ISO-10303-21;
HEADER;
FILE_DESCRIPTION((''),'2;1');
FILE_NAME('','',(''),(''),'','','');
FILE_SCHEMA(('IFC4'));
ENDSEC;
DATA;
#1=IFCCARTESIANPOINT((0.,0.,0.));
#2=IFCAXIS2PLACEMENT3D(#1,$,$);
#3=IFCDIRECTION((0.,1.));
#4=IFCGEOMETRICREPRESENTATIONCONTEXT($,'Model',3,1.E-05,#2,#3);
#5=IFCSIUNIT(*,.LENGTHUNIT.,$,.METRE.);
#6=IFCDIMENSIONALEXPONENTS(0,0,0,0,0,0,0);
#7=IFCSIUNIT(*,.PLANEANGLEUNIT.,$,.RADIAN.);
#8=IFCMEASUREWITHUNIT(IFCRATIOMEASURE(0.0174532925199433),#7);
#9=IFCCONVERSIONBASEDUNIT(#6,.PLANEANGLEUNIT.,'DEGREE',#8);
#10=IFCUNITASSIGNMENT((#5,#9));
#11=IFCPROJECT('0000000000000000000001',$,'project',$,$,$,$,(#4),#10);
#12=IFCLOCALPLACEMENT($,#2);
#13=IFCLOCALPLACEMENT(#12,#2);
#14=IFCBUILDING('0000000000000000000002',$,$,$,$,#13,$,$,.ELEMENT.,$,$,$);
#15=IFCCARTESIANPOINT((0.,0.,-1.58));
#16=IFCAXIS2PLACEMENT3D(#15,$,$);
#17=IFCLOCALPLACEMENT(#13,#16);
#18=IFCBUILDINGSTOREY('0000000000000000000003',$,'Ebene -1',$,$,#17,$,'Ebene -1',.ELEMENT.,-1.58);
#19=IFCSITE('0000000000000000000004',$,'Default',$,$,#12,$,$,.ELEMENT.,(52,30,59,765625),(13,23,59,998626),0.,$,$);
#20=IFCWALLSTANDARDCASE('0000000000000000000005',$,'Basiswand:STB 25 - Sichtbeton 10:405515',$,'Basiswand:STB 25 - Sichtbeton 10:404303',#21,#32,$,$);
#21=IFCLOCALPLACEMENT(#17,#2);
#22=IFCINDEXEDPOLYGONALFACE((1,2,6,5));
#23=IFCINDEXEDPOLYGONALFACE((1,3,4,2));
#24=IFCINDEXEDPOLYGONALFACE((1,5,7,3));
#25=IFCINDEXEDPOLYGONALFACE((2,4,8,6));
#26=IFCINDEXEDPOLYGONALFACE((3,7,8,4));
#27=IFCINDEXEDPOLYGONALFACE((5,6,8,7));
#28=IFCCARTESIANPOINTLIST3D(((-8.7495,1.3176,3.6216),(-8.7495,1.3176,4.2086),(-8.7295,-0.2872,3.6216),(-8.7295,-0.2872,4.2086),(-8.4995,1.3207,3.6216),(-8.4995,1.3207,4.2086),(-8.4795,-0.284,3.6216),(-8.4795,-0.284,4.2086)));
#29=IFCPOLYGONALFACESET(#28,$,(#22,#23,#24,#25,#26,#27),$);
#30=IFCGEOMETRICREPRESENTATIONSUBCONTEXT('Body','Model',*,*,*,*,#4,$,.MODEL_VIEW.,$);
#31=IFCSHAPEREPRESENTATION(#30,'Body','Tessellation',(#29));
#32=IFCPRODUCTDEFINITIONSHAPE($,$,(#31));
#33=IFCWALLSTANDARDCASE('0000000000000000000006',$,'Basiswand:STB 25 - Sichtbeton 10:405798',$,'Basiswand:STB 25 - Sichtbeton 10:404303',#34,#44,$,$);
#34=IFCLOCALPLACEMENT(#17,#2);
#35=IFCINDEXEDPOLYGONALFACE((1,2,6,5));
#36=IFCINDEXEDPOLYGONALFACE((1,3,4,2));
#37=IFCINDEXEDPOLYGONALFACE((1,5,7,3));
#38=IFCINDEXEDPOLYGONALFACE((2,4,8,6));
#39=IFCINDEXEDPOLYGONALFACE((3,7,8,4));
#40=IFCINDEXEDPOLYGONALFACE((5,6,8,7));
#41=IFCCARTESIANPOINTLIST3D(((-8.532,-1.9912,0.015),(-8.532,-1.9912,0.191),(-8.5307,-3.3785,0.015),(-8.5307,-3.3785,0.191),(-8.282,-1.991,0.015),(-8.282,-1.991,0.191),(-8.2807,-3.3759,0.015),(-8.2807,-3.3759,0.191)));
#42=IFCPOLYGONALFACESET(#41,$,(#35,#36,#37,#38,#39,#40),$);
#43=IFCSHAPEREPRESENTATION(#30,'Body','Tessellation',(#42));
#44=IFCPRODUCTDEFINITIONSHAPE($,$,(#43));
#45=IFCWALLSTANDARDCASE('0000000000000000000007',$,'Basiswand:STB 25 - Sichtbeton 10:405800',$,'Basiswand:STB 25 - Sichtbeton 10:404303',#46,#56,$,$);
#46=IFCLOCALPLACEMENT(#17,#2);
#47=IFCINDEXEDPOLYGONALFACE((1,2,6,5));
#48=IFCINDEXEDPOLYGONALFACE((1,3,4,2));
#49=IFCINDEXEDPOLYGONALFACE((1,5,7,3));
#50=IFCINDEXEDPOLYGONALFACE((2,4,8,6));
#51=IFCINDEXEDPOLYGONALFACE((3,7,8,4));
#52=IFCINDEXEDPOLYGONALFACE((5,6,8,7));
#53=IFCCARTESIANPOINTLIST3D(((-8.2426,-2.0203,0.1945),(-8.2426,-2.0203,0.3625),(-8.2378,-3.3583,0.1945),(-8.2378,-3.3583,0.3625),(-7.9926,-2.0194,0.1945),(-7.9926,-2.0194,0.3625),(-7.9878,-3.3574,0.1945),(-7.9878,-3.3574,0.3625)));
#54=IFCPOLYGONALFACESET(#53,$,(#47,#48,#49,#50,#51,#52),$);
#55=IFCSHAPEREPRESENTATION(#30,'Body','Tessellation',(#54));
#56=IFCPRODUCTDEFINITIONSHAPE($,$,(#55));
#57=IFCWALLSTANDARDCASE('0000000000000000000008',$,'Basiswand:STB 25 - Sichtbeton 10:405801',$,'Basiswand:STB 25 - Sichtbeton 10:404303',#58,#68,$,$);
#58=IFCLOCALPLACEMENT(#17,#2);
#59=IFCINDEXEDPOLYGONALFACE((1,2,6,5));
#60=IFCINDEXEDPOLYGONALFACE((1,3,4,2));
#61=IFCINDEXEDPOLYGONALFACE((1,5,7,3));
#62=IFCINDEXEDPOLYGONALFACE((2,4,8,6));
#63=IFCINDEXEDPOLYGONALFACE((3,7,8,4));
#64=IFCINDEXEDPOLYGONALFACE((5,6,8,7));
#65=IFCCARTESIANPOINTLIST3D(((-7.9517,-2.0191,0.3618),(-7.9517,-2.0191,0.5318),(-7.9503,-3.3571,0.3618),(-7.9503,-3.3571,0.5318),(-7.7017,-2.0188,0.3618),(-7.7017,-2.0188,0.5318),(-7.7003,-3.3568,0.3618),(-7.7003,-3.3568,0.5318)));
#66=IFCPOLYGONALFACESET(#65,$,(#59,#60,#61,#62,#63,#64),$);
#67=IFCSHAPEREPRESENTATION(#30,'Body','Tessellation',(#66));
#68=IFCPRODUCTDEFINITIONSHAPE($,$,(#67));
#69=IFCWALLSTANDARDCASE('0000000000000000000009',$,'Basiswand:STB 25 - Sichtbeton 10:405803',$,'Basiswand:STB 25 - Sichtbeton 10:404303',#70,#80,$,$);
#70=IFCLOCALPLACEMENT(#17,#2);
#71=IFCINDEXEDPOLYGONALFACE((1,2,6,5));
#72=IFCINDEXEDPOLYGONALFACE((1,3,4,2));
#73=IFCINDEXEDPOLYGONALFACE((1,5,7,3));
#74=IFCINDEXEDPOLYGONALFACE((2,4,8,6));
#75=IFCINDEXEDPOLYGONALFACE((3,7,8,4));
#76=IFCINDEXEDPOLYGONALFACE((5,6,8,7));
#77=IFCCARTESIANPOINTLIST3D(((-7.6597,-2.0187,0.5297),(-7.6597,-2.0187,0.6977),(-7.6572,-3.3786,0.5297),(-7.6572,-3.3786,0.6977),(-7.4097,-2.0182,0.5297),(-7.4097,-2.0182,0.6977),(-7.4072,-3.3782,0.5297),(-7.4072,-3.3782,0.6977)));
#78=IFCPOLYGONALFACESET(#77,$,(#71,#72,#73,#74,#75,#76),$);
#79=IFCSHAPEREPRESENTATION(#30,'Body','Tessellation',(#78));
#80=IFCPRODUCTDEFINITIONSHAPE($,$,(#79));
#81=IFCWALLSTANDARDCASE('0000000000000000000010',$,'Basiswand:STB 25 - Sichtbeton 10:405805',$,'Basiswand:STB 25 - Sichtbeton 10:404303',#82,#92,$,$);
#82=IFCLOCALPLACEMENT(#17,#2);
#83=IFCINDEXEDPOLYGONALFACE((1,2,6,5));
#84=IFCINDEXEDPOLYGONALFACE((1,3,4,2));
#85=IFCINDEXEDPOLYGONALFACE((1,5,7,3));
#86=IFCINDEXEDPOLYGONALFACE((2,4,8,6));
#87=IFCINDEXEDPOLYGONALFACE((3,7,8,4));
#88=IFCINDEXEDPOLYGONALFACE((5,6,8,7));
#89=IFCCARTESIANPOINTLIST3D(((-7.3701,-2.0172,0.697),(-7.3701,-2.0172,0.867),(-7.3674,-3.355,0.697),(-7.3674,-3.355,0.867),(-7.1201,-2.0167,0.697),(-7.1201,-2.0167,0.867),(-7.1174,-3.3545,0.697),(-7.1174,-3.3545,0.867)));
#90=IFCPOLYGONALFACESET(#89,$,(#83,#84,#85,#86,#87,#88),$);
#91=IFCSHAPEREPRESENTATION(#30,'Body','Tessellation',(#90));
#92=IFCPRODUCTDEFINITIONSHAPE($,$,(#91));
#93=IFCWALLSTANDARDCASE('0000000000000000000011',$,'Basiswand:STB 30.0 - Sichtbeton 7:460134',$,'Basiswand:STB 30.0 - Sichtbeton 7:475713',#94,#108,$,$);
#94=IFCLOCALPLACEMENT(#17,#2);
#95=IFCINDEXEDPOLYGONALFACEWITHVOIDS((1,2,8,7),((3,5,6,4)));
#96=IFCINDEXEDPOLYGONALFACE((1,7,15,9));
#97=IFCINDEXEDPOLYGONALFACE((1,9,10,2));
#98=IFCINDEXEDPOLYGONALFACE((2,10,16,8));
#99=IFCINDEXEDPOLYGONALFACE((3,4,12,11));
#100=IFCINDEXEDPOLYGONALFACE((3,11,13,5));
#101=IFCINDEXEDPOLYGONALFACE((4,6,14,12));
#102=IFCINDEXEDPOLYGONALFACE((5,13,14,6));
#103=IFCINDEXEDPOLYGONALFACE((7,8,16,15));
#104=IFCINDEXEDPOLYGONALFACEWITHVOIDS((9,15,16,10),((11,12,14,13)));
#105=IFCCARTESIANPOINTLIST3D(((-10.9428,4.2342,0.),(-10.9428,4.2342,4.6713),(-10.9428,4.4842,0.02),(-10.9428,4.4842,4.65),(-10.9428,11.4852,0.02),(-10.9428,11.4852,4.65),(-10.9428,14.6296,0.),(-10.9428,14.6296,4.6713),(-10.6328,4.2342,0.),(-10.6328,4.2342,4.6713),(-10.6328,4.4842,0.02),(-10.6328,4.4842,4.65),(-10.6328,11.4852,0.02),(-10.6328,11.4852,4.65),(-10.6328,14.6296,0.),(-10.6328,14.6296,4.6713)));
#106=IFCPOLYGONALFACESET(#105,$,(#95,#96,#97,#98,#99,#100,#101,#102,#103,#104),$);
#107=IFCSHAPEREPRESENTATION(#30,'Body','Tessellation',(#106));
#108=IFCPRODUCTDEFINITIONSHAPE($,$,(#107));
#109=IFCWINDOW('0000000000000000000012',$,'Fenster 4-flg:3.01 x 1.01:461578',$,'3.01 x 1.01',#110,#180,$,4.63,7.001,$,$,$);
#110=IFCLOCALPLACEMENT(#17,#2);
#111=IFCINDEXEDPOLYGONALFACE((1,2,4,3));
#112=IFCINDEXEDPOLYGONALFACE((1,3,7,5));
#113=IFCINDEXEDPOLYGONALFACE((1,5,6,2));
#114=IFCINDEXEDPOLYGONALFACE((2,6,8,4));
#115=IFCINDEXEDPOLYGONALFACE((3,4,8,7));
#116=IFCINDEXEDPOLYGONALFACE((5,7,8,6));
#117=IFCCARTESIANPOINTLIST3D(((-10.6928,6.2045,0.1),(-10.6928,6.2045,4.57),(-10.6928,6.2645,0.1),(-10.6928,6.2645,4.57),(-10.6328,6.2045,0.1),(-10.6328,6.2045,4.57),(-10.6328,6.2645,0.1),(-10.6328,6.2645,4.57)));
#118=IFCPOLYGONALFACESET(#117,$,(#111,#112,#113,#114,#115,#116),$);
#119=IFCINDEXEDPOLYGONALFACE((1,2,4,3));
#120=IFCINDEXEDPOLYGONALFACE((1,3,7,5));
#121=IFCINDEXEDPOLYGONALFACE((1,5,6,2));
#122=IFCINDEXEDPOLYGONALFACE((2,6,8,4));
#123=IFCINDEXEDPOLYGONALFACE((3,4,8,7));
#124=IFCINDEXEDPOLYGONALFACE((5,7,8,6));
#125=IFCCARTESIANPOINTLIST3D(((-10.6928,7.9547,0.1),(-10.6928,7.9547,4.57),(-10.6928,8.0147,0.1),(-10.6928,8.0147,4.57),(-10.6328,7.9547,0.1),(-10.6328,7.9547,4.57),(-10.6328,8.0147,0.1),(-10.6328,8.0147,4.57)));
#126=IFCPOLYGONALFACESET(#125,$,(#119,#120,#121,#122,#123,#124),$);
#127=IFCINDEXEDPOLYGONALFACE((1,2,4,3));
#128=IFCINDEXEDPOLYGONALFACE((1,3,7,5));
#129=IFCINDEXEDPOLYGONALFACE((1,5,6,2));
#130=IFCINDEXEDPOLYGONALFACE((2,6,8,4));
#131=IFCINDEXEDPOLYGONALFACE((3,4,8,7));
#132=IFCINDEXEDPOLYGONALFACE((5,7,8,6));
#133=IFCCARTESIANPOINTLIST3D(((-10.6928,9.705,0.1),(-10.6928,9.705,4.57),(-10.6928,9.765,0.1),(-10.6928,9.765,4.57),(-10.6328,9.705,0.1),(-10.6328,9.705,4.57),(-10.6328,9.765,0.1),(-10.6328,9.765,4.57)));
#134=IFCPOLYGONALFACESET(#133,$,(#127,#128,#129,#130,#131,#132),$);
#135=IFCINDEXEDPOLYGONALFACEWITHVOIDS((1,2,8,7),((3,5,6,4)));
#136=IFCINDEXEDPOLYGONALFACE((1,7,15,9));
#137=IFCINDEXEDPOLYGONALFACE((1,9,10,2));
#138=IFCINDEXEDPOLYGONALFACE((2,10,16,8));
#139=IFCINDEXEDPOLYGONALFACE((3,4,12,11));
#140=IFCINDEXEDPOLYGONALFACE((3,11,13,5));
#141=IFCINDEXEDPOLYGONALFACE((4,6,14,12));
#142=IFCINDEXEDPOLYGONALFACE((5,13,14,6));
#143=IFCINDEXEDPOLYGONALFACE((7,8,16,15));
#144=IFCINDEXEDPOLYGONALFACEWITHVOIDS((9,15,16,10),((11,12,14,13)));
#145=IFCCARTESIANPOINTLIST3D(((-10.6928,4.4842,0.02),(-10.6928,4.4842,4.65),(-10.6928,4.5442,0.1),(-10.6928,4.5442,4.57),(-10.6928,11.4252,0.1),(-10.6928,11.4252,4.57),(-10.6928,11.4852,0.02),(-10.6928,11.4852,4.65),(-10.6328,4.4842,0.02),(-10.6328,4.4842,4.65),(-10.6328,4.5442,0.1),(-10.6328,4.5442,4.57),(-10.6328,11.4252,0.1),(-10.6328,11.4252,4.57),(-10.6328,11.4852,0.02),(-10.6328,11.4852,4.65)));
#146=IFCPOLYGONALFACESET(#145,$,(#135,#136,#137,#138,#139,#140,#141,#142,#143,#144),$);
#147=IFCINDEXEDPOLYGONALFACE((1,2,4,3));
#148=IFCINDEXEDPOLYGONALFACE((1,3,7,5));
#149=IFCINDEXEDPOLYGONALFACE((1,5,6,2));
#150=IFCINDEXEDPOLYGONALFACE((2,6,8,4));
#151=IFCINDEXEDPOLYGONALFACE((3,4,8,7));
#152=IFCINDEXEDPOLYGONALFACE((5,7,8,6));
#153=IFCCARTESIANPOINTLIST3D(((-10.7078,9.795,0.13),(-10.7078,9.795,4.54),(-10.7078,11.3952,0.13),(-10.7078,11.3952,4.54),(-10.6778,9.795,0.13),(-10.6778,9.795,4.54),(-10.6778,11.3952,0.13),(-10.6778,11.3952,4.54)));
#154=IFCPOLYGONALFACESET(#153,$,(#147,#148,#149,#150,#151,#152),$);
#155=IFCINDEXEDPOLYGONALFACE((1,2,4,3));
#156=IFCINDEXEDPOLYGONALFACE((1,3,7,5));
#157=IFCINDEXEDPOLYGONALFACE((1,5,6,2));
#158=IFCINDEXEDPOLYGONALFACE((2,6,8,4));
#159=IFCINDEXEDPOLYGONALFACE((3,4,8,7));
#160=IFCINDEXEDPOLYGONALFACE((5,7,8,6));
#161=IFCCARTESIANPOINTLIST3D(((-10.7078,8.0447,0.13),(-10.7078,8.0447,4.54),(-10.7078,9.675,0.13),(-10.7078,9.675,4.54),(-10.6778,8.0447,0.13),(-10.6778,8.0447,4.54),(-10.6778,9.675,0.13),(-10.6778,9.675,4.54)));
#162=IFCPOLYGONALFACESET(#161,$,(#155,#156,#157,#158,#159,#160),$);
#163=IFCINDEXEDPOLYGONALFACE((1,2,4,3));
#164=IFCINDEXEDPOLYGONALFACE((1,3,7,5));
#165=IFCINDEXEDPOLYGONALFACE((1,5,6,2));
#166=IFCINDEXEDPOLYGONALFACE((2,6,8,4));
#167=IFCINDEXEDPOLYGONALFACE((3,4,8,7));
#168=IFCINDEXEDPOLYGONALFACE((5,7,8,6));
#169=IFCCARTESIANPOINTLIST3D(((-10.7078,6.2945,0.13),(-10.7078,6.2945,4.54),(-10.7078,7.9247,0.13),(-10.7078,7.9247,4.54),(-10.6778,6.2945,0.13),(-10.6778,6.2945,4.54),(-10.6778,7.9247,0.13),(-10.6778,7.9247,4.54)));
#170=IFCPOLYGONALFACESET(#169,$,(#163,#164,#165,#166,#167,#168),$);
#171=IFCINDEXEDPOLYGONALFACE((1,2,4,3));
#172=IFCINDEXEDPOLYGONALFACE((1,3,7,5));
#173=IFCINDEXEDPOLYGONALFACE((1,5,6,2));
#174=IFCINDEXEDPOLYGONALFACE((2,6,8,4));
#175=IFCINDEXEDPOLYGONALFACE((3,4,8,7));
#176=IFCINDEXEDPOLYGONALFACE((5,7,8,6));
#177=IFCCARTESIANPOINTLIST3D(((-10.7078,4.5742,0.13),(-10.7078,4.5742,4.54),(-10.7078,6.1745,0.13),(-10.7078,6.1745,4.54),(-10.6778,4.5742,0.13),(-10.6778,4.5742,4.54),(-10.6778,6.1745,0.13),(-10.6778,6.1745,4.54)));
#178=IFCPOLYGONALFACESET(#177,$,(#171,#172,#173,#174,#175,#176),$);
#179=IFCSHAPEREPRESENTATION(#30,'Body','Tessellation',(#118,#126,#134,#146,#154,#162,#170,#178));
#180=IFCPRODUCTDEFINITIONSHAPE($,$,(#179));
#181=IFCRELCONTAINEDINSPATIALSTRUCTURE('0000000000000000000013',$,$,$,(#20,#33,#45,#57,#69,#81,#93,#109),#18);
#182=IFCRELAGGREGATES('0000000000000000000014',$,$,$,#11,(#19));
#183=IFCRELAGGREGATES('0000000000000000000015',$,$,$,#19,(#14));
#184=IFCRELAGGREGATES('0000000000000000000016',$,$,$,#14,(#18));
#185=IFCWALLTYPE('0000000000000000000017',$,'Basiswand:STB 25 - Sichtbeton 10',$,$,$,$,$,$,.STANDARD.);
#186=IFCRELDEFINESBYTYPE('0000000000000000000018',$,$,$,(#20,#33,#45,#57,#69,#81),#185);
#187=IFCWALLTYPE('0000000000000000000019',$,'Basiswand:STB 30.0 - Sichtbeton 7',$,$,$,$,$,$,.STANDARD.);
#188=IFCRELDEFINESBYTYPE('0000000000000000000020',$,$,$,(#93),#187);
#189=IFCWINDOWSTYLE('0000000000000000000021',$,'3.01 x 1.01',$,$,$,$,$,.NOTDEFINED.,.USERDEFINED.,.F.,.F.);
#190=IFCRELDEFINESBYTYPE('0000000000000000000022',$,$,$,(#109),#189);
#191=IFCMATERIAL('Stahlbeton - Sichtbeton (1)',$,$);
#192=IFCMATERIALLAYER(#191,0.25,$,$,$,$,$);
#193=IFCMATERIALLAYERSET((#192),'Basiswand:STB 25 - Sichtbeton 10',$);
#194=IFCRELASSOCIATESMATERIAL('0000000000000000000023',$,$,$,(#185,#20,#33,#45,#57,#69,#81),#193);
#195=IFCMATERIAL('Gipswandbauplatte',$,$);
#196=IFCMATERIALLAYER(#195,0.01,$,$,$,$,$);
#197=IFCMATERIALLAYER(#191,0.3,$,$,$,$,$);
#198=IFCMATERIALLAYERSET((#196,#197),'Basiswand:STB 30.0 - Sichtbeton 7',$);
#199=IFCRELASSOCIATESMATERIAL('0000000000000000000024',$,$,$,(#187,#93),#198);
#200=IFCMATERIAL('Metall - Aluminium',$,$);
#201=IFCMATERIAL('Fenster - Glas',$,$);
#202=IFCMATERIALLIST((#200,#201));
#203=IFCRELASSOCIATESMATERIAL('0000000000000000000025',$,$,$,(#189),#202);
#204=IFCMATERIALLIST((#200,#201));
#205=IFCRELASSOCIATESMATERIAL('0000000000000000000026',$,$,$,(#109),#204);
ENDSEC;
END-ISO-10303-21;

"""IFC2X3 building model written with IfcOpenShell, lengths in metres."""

from ifc_helpers import new_model, entity, si_unit, converted_unit, direction, frame, frame_2d, origin, origin_2d_with_axis, place, context, subcontext, project, spatial, polyline, rectangle, outline, extrude, clip, halfspace, source, transform, mapped, material, material_list, layer, layer_set, layer_usage, type_object, type_shapes, element, fill, save


model = new_model("IFC2X3")

# Units and contexts
model_context = context("Model", 3, precision=1e-05, world=origin(), true_north=direction((0.0, 1.0)))
body_context = subcontext(model_context, "Body", "Model", "MODEL_VIEW")
ifc_project = project(units=[si_unit("LENGTHUNIT", "METRE"), converted_unit("PLANEANGLEUNIT", "DEGREE", entity("IfcRatioMeasure", 0.0174532925199433), si_unit("PLANEANGLEUNIT", "RADIAN"), dimensions=[0, 0, 0, 0, 0, 0, 0])], contexts=[model_context])

# Site, building, storey
site_placement = place(None, origin())
site = spatial("IfcSite", under=ifc_project, at=site_placement, Name="Default", CompositionType="ELEMENT", RefLatitude=(52, 30, 59, 765625), RefLongitude=(13, 23, 59, 998626), RefElevation=0.0)
building_placement = place(site_placement, origin())
building = spatial("IfcBuilding", under=site, at=building_placement, CompositionType="ELEMENT")
storey_placement = place(building_placement, frame((0.0, 0.0, -1.58)))
storey = spatial("IfcBuildingStorey", under=building, at=storey_placement, Name="Ebene -1", LongName="Ebene -1", CompositionType="ELEMENT", Elevation=-1.58)

# Shared definitions
ifc_material_1 = material(Name="Stahlbeton - Sichtbeton (1)")
ifc_material_2 = material(Name="Gipswandbauplatte")

# Shared definitions
ifc_layer_1 = layer(ifc_material_1, 0.25)
ifc_layer_set_1 = layer_set([ifc_layer_1], Name="Basiswand:STB 25 - Sichtbeton 10")
wall_type_1 = type_object("IfcWallType", Name="Basiswand:STB 25 - Sichtbeton 10", PredefinedType="STANDARD", material=ifc_layer_set_1)

# Walls
ifc_layer_usage_1 = layer_usage(ifc_layer_set_1, "AXIS2", "POSITIVE", -0.125)
wall_1_placement = place(storey_placement, frame((-8.6245, 1.3192, 3.6216), z_axis=(0.0, 0.0, 1.0), x_axis=(0.012485, -0.999922, 0.0)))
element("IfcWallStandardCase", 1, at=wall_1_placement, inside=storey, type_object=wall_type_1, material=ifc_layer_usage_1, Name="Basiswand:STB 25 - Sichtbeton 10:405515", ObjectType="Basiswand:STB 25 - Sichtbeton 10:404303", context=body_context, shape_type="Clipping", body=[
    clip(clip(clip(clip(extrude(rectangle(XDim=1.6049, YDim=0.25, at=frame_2d((0.8024, 0.0), x_axis=(-1.0, 0.0))), origin(), (0.0, 0.0, 1.0), 0.587), halfspace(frame((0.0, -0.125, 0.5868), z_axis=(-0.000097, 0.0, 1.0), x_axis=(0.0, 1.0, 0.0)), False)), halfspace(frame((0.0001, -0.125, 0.0), z_axis=(-1.0, 0.0, -0.000098), x_axis=(0.0, 1.0, 0.0)), False)), halfspace(frame((1.6049, -0.125, 0.0002), z_axis=(0.000097, 0.0, -1.0), x_axis=(0.0, 1.0, 0.0)), False)), halfspace(frame((1.6048, -0.125, 0.587), z_axis=(1.0, 0.0, 0.000098), x_axis=(0.0, 1.0, 0.0)), False)),
])
ifc_layer_usage_2 = layer_usage(ifc_layer_set_1, "AXIS2", "POSITIVE", -0.125)
wall_2_placement = place(storey_placement, frame((-8.407, -1.9911, 0.015), z_axis=(0.0, 0.0, 1.0), x_axis=(0.000901, -1.0, 0.0)))
element("IfcWallStandardCase", 2, at=wall_2_placement, inside=storey, type_object=wall_type_1, material=ifc_layer_usage_2, Name="Basiswand:STB 25 - Sichtbeton 10:405798", ObjectType="Basiswand:STB 25 - Sichtbeton 10:404303", context=body_context, shape_type="SweptSolid", body=[
    extrude(outline(polyline([(1.3872, -0.125), (1.3849, 0.125), (0.0, 0.125), (0.0, -0.125), (1.3872, -0.125)])), origin(), (0.0, 0.0, 1.0), 0.176),
])
ifc_layer_usage_3 = layer_usage(ifc_layer_set_1, "AXIS2", "POSITIVE", -0.125)
wall_3_placement = place(storey_placement, frame((-8.1176, -2.0199, 0.1945), z_axis=(0.0, 0.0, 1.0), x_axis=(0.003598, -0.999994, 0.0)))
element("IfcWallStandardCase", 3, at=wall_3_placement, inside=storey, type_object=wall_type_1, material=ifc_layer_usage_3, Name="Basiswand:STB 25 - Sichtbeton 10:405800", ObjectType="Basiswand:STB 25 - Sichtbeton 10:404303", context=body_context, shape_type="SweptSolid", body=[
    extrude(rectangle(XDim=1.338, YDim=0.25, at=frame_2d((0.669, 0.0), x_axis=(-1.0, 0.0))), origin(), (0.0, 0.0, 1.0), 0.168),
])
ifc_layer_usage_4 = layer_usage(ifc_layer_set_1, "AXIS2", "POSITIVE", -0.125)
wall_4_placement = place(storey_placement, frame((-7.8267, -2.019, 0.3618), z_axis=(0.0, 0.0, 1.0), x_axis=(0.001062, -0.999999, 0.0)))
element("IfcWallStandardCase", 4, at=wall_4_placement, inside=storey, type_object=wall_type_1, material=ifc_layer_usage_4, Name="Basiswand:STB 25 - Sichtbeton 10:405801", ObjectType="Basiswand:STB 25 - Sichtbeton 10:404303", context=body_context, shape_type="SweptSolid", body=[
    extrude(rectangle(XDim=1.338, YDim=0.25, at=frame_2d((0.669, 0.0), x_axis=(-1.0, 0.0))), origin(), (0.0, 0.0, 1.0), 0.17),
])
ifc_layer_usage_5 = layer_usage(ifc_layer_set_1, "AXIS2", "POSITIVE", -0.125)
wall_5_placement = place(storey_placement, frame((-7.5347, -2.0185, 0.5297), z_axis=(0.0, 0.0, 1.0), x_axis=(0.001861, -0.999998, 0.0)))
element("IfcWallStandardCase", 5, at=wall_5_placement, inside=storey, type_object=wall_type_1, material=ifc_layer_usage_5, Name="Basiswand:STB 25 - Sichtbeton 10:405803", ObjectType="Basiswand:STB 25 - Sichtbeton 10:404303", context=body_context, shape_type="SweptSolid", body=[
    extrude(rectangle(XDim=1.3599, YDim=0.25, at=frame_2d((0.68, 0.0), x_axis=(-1.0, 0.0))), origin(), (0.0, 0.0, 1.0), 0.168),
])
ifc_layer_usage_6 = layer_usage(ifc_layer_set_1, "AXIS2", "POSITIVE", -0.125)
wall_6_placement = place(storey_placement, frame((-7.2451, -2.017, 0.697), z_axis=(0.0, 0.0, 1.0), x_axis=(0.002011, -0.999998, 0.0)))
element("IfcWallStandardCase", 6, at=wall_6_placement, inside=storey, type_object=wall_type_1, material=ifc_layer_usage_6, Name="Basiswand:STB 25 - Sichtbeton 10:405805", ObjectType="Basiswand:STB 25 - Sichtbeton 10:404303", context=body_context, shape_type="SweptSolid", body=[
    extrude(rectangle(XDim=1.3378, YDim=0.25, at=frame_2d((0.6689, 0.0), x_axis=(-1.0, 0.0))), origin(), (0.0, 0.0, 1.0), 0.17),
])

# Wall, opening, window
ifc_layer_2 = layer(ifc_material_2, 0.01)
ifc_layer_3 = layer(ifc_material_1, 0.3)
ifc_layer_set_2 = layer_set([ifc_layer_2, ifc_layer_3], Name="Basiswand:STB 30.0 - Sichtbeton 7")
ifc_layer_usage_7 = layer_usage(ifc_layer_set_2, "AXIS2", "NEGATIVE", 0.155)
wall_type_2 = type_object("IfcWallType", Name="Basiswand:STB 30.0 - Sichtbeton 7", PredefinedType="STANDARD", material=ifc_layer_set_2)
wall_7_placement = place(storey_placement, frame((-10.7878, 14.6296, 0.0), z_axis=(0.0, 0.0, 1.0), x_axis=(0.0, -1.0, 0.0)))
wall_7 = element("IfcWallStandardCase", 7, at=wall_7_placement, inside=storey, type_object=wall_type_2, material=ifc_layer_usage_7, Name="Basiswand:STB 30.0 - Sichtbeton 7:460134", ObjectType="Basiswand:STB 30.0 - Sichtbeton 7:475713", context=body_context, shape_type="SweptSolid", body=[
    extrude(rectangle(XDim=10.3953, YDim=0.31, at=frame_2d((5.1977, 0.0), x_axis=(-1.0, 0.0))), origin(), (0.0, 0.0, 1.0), 4.6713),
])
opening_1_placement = place(wall_7_placement, frame((3.1443, -0.155, 0.02)))
opening_1 = element("IfcOpeningElement", 8, at=opening_1_placement, cuts=wall_7, ObjectType="Opening", context=body_context, shape_type="SweptSolid", body=[
    extrude(rectangle(XDim=4.63, YDim=7.001, at=frame_2d((2.315, 3.5005), x_axis=(1.0, 0.0))), frame((0.0, 0.0, 0.0), z_axis=(0.0, 1.0, 0.0), x_axis=(0.0, 0.0, 1.0)), (0.0, 0.0, 1.0), 0.31),
])
ifc_material_3 = material(Name="Metall - Aluminium")
ifc_material_4 = material(Name="Fenster - Glas")
ifc_material_list_1 = material_list([ifc_material_3, ifc_material_4])
ifc_material_list_2 = material_list([ifc_material_3, ifc_material_4])
window_style = type_object("IfcWindowStyle", Name="3.01 x 1.01", ConstructionType="NOTDEFINED", OperationType="USERDEFINED", ParameterTakesPrecedence=False, Sizeable=False, material=ifc_material_list_2)
shared_shape = source(origin(), body_context, "Body", "SweptSolid", [
    extrude(rectangle(XDim=0.06, YDim=0.06, at=frame_2d((0.0, 0.0), x_axis=(1.0, 0.0))), frame((5.2508, 0.28, 0.08), z_axis=(0.0, 0.0, 1.0), x_axis=(-1.0, 0.0, 0.0)), (0.0, 0.0, 1.0), 4.47),
    extrude(rectangle(XDim=0.06, YDim=0.06, at=origin_2d_with_axis()), frame((3.5005, 0.28, 0.08), z_axis=(0.0, 0.0, 1.0), x_axis=(-1.0, 0.0, 0.0)), (0.0, 0.0, 1.0), 4.47),
    extrude(rectangle(XDim=0.06, YDim=0.06, at=frame_2d((0.0, 0.0), x_axis=(1.0, 0.0))), frame((1.7503, 0.28, 0.08), z_axis=(0.0, 0.0, 1.0), x_axis=(-1.0, 0.0, 0.0)), (0.0, 0.0, 1.0), 4.47),
    extrude(outline(polyline([(-2.315, -3.5005), (2.315, -3.5005), (2.315, 3.5005), (-2.315, 3.5005), (-2.315, -3.5005)]), holes=[polyline([(-2.235, -3.4405), (-2.235, 3.4405), (2.235, 3.4405), (2.235, -3.4405), (-2.235, -3.4405)])]), frame((3.5005, 0.25, 2.315), z_axis=(0.0, 1.0, 0.0), x_axis=(0.0, 0.0, -1.0)), (0.0, 0.0, 1.0), 0.06),
    extrude(rectangle(XDim=0.03, YDim=1.6002, at=frame_2d((0.0, 0.0), x_axis=(1.0, 0.0))), frame((0.8901, 0.25, 0.11), z_axis=(0.0, 0.0, 1.0), x_axis=(0.0, 1.0, 0.0)), (0.0, 0.0, 1.0), 4.41),
    extrude(rectangle(XDim=0.03, YDim=1.6302, at=frame_2d((0.0, 0.0), x_axis=(1.0, 0.0))), frame((2.6254, 0.25, 0.11), z_axis=(0.0, 0.0, 1.0), x_axis=(0.0, 1.0, 0.0)), (0.0, 0.0, 1.0), 4.41),
    extrude(rectangle(XDim=0.03, YDim=1.6302, at=frame_2d((0.0, 0.0), x_axis=(1.0, 0.0))), frame((4.3756, 0.25, 0.11), z_axis=(0.0, 0.0, 1.0), x_axis=(0.0, 1.0, 0.0)), (0.0, 0.0, 1.0), 4.41),
    extrude(rectangle(XDim=0.03, YDim=1.6002, at=frame_2d((0.0, 0.0), x_axis=(1.0, 0.0))), frame((6.1109, 0.25, 0.11), z_axis=(0.0, 0.0, 1.0), x_axis=(0.0, 1.0, 0.0)), (0.0, 0.0, 1.0), 4.41),
])
type_shapes(window_style, [shared_shape])
window_placement = place(opening_1_placement, origin())
window = element("IfcWindow", 9, at=window_placement, inside=storey, type_object=window_style, material=ifc_material_list_1, Name="Fenster 4-flg:3.01 x 1.01:461578", ObjectType="3.01 x 1.01", OverallHeight=4.63, OverallWidth=7.001, context=body_context, shape_type="MappedRepresentation", body=[
    mapped(shared_shape, transform((0.0, 0.0, 0.0), scale=1.0)),
])
fill(opening_1, window)

save(model, "model.ifc")
